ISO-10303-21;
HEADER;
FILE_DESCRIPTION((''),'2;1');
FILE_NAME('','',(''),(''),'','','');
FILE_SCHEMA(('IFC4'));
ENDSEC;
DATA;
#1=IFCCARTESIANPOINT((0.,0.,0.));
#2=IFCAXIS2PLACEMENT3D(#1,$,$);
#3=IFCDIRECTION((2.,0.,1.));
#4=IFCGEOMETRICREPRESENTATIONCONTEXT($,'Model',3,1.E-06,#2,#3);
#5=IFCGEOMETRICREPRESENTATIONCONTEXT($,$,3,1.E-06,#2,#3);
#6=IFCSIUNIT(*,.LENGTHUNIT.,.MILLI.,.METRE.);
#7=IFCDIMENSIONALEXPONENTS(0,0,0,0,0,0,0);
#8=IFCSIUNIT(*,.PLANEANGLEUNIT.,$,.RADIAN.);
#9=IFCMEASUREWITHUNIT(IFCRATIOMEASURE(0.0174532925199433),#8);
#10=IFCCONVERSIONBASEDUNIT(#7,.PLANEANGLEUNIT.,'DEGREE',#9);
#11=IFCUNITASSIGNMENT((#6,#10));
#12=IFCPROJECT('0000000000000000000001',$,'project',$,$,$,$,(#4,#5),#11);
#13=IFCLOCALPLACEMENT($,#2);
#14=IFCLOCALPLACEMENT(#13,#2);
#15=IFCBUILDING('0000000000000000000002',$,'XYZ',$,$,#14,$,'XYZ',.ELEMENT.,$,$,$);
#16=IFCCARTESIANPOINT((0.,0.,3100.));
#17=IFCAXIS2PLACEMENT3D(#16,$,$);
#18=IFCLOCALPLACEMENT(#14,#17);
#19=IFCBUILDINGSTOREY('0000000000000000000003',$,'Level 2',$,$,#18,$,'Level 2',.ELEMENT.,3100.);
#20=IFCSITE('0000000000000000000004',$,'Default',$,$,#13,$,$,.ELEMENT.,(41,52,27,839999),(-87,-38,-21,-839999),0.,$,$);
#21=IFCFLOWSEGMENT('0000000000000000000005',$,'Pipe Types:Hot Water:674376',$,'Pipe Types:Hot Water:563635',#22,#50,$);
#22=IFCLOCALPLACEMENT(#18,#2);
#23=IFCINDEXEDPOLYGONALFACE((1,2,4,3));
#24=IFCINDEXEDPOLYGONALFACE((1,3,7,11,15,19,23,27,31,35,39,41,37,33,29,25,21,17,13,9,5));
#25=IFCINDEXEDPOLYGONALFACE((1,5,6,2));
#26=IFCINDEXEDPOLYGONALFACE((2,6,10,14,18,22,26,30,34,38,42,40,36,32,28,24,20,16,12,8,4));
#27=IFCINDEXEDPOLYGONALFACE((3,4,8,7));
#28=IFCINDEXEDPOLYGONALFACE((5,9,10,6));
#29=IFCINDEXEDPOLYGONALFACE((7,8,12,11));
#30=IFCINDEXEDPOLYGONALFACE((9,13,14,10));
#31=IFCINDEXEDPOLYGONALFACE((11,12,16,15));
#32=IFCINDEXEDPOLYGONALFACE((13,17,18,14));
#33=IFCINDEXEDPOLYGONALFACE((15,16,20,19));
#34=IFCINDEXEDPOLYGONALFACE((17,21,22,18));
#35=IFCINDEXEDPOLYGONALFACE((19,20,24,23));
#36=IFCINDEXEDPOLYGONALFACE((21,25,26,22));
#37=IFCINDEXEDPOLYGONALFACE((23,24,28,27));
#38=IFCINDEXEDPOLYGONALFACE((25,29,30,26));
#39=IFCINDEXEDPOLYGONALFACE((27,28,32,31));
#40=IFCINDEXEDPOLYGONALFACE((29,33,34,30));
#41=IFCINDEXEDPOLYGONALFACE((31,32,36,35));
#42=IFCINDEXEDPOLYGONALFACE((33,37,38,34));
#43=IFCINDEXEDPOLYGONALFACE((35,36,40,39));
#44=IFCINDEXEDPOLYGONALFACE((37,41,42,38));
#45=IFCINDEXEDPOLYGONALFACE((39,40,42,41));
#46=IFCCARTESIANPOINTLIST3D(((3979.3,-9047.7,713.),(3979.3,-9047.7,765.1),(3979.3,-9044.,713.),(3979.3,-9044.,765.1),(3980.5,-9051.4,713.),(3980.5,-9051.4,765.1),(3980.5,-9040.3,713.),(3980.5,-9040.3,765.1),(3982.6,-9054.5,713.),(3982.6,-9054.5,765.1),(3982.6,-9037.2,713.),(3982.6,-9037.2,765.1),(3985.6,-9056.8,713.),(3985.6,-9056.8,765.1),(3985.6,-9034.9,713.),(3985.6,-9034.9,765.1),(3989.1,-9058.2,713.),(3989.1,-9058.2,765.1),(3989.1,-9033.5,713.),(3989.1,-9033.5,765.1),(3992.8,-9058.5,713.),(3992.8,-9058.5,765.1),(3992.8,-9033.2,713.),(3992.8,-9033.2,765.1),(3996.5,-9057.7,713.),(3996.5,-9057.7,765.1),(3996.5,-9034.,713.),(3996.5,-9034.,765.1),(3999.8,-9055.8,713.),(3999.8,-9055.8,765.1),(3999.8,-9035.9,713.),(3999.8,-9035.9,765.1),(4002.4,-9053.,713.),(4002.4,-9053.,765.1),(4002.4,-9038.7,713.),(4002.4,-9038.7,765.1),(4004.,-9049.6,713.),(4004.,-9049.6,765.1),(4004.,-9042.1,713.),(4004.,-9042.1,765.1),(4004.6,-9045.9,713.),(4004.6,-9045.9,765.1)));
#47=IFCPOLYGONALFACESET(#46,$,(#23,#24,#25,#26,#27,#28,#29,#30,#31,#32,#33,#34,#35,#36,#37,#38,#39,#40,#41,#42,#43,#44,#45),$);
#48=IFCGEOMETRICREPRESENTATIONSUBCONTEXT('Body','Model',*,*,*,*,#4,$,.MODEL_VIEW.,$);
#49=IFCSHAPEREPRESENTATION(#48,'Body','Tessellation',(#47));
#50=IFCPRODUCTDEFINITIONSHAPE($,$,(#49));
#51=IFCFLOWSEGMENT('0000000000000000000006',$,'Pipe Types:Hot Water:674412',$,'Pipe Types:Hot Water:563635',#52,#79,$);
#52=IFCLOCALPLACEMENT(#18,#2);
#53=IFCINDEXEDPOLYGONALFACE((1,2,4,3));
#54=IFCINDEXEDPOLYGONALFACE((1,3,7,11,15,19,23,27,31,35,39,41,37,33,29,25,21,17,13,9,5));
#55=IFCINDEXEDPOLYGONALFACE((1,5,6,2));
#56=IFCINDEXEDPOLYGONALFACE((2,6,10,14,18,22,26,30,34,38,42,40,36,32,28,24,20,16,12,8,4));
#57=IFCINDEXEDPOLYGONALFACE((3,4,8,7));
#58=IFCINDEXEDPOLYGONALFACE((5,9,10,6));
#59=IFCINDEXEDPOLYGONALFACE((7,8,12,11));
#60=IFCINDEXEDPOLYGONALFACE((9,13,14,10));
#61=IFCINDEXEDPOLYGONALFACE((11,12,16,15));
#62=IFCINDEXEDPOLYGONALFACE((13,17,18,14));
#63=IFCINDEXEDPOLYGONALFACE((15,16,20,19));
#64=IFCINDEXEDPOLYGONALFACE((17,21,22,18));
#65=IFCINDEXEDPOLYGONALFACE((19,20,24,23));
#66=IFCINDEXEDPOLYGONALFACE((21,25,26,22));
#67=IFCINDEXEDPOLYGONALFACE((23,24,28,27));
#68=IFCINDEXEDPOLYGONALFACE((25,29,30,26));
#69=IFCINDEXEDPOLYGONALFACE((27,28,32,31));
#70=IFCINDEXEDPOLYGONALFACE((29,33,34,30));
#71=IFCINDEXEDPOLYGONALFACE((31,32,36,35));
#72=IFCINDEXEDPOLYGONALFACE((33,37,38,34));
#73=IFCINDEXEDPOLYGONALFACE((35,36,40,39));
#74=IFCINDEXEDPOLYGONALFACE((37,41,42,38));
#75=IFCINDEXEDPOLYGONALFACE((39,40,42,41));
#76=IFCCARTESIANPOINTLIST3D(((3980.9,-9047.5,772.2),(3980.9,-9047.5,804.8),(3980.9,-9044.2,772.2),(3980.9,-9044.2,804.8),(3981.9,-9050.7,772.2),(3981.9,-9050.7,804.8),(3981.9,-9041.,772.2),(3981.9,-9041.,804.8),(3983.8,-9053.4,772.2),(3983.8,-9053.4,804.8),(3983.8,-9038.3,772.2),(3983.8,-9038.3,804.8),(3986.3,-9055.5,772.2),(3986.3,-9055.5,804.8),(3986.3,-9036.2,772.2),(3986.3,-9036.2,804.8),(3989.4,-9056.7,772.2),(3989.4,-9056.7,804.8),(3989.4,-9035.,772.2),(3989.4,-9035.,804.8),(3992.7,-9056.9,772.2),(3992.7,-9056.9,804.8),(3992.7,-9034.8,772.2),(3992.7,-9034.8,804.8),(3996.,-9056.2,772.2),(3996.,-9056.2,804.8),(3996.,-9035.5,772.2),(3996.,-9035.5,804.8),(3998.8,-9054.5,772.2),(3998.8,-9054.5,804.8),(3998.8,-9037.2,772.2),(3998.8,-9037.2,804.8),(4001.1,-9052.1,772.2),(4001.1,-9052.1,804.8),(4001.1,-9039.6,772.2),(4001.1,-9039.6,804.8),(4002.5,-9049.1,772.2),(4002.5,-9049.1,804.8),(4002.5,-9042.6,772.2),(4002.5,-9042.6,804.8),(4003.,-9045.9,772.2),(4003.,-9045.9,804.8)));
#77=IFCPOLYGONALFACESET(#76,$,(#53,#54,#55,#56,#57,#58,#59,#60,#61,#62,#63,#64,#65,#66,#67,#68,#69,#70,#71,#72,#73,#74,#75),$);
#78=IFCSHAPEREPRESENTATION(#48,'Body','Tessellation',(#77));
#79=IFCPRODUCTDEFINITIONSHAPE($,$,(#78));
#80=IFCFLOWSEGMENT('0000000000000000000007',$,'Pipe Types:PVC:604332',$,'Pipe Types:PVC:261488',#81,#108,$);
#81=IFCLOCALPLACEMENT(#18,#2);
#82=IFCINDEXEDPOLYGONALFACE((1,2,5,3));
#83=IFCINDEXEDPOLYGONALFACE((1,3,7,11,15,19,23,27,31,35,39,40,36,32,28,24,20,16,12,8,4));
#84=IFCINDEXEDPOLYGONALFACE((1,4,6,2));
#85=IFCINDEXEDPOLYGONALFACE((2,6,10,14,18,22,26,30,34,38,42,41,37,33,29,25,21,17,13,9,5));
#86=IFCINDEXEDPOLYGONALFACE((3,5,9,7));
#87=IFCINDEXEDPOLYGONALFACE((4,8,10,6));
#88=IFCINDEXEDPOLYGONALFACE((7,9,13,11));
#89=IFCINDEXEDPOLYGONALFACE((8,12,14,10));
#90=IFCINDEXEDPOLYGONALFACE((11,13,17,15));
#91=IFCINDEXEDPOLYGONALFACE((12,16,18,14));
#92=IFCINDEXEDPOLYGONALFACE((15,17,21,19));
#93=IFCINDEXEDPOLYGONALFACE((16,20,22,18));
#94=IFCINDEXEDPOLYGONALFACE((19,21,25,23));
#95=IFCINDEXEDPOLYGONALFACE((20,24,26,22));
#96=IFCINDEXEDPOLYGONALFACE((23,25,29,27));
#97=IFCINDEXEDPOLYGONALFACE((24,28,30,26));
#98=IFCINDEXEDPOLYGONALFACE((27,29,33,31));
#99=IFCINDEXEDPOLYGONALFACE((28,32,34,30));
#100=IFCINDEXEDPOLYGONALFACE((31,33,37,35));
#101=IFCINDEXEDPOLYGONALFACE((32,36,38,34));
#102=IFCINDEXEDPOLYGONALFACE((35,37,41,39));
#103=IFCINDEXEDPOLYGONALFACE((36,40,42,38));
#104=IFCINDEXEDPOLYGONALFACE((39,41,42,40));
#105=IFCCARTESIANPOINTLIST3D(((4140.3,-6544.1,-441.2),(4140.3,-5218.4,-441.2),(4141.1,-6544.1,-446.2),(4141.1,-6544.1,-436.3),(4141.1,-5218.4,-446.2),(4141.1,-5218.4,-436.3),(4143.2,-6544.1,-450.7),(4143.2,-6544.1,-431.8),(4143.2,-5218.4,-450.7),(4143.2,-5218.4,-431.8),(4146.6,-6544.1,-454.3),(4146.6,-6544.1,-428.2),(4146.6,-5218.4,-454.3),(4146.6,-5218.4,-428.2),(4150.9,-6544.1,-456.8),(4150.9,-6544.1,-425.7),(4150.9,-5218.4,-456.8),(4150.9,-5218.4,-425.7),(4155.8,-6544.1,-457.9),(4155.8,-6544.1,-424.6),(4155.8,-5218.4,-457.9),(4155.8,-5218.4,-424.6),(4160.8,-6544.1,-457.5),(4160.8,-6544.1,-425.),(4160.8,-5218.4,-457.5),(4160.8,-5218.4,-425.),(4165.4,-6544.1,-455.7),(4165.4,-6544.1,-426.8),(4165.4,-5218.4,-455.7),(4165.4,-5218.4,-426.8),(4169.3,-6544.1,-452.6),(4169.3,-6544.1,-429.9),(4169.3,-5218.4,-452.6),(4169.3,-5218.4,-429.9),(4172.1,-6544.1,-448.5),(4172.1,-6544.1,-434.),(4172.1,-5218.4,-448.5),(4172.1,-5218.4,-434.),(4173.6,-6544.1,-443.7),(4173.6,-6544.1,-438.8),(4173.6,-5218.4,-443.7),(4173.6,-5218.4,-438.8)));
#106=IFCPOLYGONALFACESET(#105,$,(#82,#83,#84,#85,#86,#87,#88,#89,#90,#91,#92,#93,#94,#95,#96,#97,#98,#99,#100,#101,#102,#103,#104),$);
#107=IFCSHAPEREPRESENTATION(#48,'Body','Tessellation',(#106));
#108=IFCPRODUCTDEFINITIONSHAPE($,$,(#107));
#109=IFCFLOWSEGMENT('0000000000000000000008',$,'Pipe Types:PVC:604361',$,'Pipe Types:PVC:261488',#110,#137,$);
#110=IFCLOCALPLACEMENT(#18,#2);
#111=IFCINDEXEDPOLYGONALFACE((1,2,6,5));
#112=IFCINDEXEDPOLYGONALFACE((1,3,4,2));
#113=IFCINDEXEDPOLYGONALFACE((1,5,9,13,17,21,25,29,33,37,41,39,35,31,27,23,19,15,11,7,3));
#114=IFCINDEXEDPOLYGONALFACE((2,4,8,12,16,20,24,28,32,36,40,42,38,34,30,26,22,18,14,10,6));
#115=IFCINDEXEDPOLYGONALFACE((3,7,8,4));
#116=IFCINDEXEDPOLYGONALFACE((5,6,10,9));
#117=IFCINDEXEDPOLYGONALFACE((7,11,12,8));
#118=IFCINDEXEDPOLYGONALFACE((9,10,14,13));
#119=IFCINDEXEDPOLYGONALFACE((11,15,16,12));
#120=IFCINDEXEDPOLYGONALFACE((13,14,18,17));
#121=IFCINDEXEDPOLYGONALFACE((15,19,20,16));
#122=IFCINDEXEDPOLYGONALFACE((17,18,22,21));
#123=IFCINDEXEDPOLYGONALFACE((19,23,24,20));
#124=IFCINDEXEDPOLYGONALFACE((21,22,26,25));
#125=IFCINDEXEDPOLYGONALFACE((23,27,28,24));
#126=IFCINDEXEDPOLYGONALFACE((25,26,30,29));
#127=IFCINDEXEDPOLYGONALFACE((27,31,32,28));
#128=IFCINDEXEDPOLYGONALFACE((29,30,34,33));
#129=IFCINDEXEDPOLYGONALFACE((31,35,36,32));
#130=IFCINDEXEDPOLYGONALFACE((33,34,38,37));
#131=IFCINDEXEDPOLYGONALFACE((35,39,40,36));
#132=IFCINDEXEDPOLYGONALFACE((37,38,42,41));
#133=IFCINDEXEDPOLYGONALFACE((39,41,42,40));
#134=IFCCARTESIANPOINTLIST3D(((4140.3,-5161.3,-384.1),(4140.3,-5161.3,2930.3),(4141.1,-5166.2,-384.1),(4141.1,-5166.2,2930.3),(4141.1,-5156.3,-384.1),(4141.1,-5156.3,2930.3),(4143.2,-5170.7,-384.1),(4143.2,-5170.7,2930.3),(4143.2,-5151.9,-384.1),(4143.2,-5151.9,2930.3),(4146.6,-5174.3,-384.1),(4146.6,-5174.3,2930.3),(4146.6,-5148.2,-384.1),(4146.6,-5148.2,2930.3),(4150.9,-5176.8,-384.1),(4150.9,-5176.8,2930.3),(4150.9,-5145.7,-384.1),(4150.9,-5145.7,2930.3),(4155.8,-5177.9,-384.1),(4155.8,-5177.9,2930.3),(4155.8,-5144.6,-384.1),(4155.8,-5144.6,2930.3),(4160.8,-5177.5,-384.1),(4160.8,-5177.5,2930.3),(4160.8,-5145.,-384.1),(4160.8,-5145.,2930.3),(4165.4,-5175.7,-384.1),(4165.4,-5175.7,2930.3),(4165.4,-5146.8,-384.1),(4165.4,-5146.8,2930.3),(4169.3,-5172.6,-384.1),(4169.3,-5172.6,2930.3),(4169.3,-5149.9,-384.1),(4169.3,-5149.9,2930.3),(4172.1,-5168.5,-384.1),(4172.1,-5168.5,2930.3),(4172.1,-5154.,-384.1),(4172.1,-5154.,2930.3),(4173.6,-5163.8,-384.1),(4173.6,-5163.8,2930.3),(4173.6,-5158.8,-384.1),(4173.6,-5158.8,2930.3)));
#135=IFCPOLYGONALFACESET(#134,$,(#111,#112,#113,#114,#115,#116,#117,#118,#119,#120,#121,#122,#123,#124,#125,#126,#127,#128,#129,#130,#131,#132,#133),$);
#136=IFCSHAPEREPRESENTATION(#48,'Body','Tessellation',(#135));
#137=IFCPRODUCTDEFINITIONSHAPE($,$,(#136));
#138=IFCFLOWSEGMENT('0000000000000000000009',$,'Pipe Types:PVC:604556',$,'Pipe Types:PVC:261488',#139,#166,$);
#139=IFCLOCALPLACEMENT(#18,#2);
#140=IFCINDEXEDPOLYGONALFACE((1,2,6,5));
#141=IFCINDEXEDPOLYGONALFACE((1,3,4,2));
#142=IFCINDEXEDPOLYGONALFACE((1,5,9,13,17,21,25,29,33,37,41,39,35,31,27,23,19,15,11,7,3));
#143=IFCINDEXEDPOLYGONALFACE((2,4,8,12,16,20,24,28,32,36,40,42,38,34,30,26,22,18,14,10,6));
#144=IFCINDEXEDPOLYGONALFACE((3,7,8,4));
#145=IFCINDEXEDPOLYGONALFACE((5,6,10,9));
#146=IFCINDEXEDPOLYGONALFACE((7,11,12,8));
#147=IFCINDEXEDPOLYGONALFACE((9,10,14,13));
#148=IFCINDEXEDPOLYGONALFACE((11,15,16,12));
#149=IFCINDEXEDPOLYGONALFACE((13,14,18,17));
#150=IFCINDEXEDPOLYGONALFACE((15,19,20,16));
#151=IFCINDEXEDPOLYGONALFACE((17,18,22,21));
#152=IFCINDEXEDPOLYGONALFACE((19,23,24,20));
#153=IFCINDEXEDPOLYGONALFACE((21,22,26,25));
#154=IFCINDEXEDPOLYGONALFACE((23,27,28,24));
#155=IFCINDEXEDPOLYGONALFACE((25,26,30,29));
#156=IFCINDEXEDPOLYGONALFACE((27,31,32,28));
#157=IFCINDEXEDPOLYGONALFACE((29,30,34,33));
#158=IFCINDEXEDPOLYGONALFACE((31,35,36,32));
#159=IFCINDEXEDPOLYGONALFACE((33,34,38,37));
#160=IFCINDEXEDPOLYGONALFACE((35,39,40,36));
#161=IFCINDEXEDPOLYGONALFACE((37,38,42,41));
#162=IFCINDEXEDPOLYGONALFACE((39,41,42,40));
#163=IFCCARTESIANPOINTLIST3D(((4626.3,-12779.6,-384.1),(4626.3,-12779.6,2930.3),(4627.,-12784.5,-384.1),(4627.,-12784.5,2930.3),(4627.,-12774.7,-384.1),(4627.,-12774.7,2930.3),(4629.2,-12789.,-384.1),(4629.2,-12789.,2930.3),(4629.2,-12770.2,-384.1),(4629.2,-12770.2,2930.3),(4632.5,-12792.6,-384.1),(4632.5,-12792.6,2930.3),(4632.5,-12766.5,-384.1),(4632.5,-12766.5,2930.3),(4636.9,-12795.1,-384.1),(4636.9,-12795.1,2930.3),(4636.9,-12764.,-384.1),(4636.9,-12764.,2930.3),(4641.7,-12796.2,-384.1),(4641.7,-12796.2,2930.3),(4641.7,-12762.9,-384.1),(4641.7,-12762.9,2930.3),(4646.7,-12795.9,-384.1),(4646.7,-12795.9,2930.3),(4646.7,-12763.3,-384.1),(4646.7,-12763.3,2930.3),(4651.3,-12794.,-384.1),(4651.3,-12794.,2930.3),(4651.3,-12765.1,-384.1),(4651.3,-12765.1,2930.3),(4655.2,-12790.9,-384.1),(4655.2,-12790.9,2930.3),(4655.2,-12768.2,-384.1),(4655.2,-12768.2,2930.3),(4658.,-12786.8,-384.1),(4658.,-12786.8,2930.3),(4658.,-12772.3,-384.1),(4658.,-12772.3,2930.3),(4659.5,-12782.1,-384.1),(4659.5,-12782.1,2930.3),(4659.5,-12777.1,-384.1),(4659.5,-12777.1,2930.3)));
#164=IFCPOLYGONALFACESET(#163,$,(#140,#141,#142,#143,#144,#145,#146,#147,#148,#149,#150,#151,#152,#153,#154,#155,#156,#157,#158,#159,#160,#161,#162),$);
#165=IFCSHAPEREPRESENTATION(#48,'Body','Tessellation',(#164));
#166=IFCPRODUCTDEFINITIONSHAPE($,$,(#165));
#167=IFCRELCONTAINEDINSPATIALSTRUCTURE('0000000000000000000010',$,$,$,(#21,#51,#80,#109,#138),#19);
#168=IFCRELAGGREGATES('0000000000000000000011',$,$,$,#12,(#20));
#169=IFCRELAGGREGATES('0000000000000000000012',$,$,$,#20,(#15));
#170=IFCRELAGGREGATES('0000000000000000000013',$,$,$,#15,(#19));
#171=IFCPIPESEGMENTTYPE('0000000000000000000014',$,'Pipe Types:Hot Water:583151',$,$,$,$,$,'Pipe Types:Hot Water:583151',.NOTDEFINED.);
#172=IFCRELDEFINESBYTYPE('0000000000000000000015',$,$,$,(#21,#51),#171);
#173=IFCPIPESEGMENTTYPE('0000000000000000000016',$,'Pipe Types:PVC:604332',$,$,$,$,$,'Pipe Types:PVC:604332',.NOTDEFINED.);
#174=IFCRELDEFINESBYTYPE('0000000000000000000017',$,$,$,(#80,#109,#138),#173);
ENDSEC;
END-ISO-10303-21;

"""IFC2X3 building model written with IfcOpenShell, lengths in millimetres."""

from ifc_helpers import new_model, entity, si_unit, converted_unit, direction, frame, frame_2d, origin, origin_2d_with_axis, place, context, subcontext, project, spatial, circle, extrude, type_object, element, save


model = new_model("IFC2X3")

# Units and contexts
model_context = context("Model", 3, precision=1e-06, world=origin(), true_north=direction((2.0, 0.0, 1.0)))
context_of_model = context(None, 3, precision=1e-06, world=origin(), true_north=direction((2.0, 0.0, 1.0)))
body_context = subcontext(model_context, "Body", "Model", "MODEL_VIEW")
ifc_project = project(units=[si_unit("LENGTHUNIT", "METRE", prefix="MILLI"), converted_unit("PLANEANGLEUNIT", "DEGREE", entity("IfcRatioMeasure", 0.0174532925199433), si_unit("PLANEANGLEUNIT", "RADIAN"), dimensions=[0, 0, 0, 0, 0, 0, 0])], contexts=[model_context, context_of_model])

# Site, building, storey
site_placement = place(None, origin())
site = spatial("IfcSite", under=ifc_project, at=site_placement, Name="Default", CompositionType="ELEMENT", RefLatitude=(41, 52, 27, 839999), RefLongitude=(-87, -38, -21, -839999), RefElevation=0.0)
building_placement = place(site_placement, origin())
building = spatial("IfcBuilding", under=site, at=building_placement, Name="XYZ", LongName="XYZ", CompositionType="ELEMENT")
storey_placement = place(building_placement, frame((0.0, 0.0, 3100.0)))
storey = spatial("IfcBuildingStorey", under=building, at=storey_placement, Name="Level 2", LongName="Level 2", CompositionType="ELEMENT", Elevation=3100.0)

# Flow segments
pipe_segment_type_1 = type_object("IfcPipeSegmentType", Name="Pipe Types:Hot Water:583151", ElementType="Pipe Types:Hot Water:583151", PredefinedType="NOTDEFINED")
flow_segment_1_placement = place(storey_placement, origin())
element("IfcFlowSegment", 1, at=flow_segment_1_placement, inside=storey, type_object=pipe_segment_type_1, Name="Pipe Types:Hot Water:674376", ObjectType="Pipe Types:Hot Water:563635", context=body_context, shape_type="SweptSolid", body=[
    extrude(circle(Radius=12.7, at=origin_2d_with_axis()), frame((3991.9, -9045.9, 713.0)), (0.0, 0.0, 1.0), 52.0),
])
flow_segment_2_placement = place(storey_placement, origin())
element("IfcFlowSegment", 2, at=flow_segment_2_placement, inside=storey, type_object=pipe_segment_type_1, Name="Pipe Types:Hot Water:674412", ObjectType="Pipe Types:Hot Water:563635", context=body_context, shape_type="SweptSolid", body=[
    extrude(circle(Radius=11.1, at=origin_2d_with_axis()), frame((3991.9, -9045.9, 772.2)), (0.0, 0.0, 1.0), 32.5),
])
pipe_segment_type_2 = type_object("IfcPipeSegmentType", Name="Pipe Types:PVC:604332", ElementType="Pipe Types:PVC:604332", PredefinedType="NOTDEFINED")
flow_segment_3_placement = place(storey_placement, origin())
element("IfcFlowSegment", 3, at=flow_segment_3_placement, inside=storey, type_object=pipe_segment_type_2, Name="Pipe Types:PVC:604332", ObjectType="Pipe Types:PVC:261488", context=body_context, shape_type="SweptSolid", body=[
    extrude(circle(Radius=16.7, at=frame_2d((0.0, 0.0), x_axis=(1.0, 0.0))), frame((4157.0, -6544.1, -441.2), z_axis=(0.0, 1.0, 0.0), x_axis=(-1.0, 0.0, 0.0)), (0.0, 0.0, 1.0), 1325.7),
])
flow_segment_4_placement = place(storey_placement, origin())
element("IfcFlowSegment", 4, at=flow_segment_4_placement, inside=storey, type_object=pipe_segment_type_2, Name="Pipe Types:PVC:604361", ObjectType="Pipe Types:PVC:261488", context=body_context, shape_type="SweptSolid", body=[
    extrude(circle(Radius=16.7, at=origin_2d_with_axis()), frame((4157.0, -5161.3, -384.1), z_axis=(0.0, 0.0, 1.0), x_axis=(-1.0, 0.0, 0.0)), (0.0, 0.0, 1.0), 3314.4),
])
flow_segment_5_placement = place(storey_placement, origin())
element("IfcFlowSegment", 5, at=flow_segment_5_placement, inside=storey, type_object=pipe_segment_type_2, Name="Pipe Types:PVC:604556", ObjectType="Pipe Types:PVC:261488", context=body_context, shape_type="SweptSolid", body=[
    extrude(circle(Radius=16.7, at=frame_2d((0.0, 0.0), x_axis=(1.0, 0.0))), frame((4643.0, -12779.6, -384.1), z_axis=(0.0, 0.0, 1.0), x_axis=(-1.0, 0.0, 0.0)), (0.0, 0.0, 1.0), 3314.4),
])

save(model, "model.ifc")
